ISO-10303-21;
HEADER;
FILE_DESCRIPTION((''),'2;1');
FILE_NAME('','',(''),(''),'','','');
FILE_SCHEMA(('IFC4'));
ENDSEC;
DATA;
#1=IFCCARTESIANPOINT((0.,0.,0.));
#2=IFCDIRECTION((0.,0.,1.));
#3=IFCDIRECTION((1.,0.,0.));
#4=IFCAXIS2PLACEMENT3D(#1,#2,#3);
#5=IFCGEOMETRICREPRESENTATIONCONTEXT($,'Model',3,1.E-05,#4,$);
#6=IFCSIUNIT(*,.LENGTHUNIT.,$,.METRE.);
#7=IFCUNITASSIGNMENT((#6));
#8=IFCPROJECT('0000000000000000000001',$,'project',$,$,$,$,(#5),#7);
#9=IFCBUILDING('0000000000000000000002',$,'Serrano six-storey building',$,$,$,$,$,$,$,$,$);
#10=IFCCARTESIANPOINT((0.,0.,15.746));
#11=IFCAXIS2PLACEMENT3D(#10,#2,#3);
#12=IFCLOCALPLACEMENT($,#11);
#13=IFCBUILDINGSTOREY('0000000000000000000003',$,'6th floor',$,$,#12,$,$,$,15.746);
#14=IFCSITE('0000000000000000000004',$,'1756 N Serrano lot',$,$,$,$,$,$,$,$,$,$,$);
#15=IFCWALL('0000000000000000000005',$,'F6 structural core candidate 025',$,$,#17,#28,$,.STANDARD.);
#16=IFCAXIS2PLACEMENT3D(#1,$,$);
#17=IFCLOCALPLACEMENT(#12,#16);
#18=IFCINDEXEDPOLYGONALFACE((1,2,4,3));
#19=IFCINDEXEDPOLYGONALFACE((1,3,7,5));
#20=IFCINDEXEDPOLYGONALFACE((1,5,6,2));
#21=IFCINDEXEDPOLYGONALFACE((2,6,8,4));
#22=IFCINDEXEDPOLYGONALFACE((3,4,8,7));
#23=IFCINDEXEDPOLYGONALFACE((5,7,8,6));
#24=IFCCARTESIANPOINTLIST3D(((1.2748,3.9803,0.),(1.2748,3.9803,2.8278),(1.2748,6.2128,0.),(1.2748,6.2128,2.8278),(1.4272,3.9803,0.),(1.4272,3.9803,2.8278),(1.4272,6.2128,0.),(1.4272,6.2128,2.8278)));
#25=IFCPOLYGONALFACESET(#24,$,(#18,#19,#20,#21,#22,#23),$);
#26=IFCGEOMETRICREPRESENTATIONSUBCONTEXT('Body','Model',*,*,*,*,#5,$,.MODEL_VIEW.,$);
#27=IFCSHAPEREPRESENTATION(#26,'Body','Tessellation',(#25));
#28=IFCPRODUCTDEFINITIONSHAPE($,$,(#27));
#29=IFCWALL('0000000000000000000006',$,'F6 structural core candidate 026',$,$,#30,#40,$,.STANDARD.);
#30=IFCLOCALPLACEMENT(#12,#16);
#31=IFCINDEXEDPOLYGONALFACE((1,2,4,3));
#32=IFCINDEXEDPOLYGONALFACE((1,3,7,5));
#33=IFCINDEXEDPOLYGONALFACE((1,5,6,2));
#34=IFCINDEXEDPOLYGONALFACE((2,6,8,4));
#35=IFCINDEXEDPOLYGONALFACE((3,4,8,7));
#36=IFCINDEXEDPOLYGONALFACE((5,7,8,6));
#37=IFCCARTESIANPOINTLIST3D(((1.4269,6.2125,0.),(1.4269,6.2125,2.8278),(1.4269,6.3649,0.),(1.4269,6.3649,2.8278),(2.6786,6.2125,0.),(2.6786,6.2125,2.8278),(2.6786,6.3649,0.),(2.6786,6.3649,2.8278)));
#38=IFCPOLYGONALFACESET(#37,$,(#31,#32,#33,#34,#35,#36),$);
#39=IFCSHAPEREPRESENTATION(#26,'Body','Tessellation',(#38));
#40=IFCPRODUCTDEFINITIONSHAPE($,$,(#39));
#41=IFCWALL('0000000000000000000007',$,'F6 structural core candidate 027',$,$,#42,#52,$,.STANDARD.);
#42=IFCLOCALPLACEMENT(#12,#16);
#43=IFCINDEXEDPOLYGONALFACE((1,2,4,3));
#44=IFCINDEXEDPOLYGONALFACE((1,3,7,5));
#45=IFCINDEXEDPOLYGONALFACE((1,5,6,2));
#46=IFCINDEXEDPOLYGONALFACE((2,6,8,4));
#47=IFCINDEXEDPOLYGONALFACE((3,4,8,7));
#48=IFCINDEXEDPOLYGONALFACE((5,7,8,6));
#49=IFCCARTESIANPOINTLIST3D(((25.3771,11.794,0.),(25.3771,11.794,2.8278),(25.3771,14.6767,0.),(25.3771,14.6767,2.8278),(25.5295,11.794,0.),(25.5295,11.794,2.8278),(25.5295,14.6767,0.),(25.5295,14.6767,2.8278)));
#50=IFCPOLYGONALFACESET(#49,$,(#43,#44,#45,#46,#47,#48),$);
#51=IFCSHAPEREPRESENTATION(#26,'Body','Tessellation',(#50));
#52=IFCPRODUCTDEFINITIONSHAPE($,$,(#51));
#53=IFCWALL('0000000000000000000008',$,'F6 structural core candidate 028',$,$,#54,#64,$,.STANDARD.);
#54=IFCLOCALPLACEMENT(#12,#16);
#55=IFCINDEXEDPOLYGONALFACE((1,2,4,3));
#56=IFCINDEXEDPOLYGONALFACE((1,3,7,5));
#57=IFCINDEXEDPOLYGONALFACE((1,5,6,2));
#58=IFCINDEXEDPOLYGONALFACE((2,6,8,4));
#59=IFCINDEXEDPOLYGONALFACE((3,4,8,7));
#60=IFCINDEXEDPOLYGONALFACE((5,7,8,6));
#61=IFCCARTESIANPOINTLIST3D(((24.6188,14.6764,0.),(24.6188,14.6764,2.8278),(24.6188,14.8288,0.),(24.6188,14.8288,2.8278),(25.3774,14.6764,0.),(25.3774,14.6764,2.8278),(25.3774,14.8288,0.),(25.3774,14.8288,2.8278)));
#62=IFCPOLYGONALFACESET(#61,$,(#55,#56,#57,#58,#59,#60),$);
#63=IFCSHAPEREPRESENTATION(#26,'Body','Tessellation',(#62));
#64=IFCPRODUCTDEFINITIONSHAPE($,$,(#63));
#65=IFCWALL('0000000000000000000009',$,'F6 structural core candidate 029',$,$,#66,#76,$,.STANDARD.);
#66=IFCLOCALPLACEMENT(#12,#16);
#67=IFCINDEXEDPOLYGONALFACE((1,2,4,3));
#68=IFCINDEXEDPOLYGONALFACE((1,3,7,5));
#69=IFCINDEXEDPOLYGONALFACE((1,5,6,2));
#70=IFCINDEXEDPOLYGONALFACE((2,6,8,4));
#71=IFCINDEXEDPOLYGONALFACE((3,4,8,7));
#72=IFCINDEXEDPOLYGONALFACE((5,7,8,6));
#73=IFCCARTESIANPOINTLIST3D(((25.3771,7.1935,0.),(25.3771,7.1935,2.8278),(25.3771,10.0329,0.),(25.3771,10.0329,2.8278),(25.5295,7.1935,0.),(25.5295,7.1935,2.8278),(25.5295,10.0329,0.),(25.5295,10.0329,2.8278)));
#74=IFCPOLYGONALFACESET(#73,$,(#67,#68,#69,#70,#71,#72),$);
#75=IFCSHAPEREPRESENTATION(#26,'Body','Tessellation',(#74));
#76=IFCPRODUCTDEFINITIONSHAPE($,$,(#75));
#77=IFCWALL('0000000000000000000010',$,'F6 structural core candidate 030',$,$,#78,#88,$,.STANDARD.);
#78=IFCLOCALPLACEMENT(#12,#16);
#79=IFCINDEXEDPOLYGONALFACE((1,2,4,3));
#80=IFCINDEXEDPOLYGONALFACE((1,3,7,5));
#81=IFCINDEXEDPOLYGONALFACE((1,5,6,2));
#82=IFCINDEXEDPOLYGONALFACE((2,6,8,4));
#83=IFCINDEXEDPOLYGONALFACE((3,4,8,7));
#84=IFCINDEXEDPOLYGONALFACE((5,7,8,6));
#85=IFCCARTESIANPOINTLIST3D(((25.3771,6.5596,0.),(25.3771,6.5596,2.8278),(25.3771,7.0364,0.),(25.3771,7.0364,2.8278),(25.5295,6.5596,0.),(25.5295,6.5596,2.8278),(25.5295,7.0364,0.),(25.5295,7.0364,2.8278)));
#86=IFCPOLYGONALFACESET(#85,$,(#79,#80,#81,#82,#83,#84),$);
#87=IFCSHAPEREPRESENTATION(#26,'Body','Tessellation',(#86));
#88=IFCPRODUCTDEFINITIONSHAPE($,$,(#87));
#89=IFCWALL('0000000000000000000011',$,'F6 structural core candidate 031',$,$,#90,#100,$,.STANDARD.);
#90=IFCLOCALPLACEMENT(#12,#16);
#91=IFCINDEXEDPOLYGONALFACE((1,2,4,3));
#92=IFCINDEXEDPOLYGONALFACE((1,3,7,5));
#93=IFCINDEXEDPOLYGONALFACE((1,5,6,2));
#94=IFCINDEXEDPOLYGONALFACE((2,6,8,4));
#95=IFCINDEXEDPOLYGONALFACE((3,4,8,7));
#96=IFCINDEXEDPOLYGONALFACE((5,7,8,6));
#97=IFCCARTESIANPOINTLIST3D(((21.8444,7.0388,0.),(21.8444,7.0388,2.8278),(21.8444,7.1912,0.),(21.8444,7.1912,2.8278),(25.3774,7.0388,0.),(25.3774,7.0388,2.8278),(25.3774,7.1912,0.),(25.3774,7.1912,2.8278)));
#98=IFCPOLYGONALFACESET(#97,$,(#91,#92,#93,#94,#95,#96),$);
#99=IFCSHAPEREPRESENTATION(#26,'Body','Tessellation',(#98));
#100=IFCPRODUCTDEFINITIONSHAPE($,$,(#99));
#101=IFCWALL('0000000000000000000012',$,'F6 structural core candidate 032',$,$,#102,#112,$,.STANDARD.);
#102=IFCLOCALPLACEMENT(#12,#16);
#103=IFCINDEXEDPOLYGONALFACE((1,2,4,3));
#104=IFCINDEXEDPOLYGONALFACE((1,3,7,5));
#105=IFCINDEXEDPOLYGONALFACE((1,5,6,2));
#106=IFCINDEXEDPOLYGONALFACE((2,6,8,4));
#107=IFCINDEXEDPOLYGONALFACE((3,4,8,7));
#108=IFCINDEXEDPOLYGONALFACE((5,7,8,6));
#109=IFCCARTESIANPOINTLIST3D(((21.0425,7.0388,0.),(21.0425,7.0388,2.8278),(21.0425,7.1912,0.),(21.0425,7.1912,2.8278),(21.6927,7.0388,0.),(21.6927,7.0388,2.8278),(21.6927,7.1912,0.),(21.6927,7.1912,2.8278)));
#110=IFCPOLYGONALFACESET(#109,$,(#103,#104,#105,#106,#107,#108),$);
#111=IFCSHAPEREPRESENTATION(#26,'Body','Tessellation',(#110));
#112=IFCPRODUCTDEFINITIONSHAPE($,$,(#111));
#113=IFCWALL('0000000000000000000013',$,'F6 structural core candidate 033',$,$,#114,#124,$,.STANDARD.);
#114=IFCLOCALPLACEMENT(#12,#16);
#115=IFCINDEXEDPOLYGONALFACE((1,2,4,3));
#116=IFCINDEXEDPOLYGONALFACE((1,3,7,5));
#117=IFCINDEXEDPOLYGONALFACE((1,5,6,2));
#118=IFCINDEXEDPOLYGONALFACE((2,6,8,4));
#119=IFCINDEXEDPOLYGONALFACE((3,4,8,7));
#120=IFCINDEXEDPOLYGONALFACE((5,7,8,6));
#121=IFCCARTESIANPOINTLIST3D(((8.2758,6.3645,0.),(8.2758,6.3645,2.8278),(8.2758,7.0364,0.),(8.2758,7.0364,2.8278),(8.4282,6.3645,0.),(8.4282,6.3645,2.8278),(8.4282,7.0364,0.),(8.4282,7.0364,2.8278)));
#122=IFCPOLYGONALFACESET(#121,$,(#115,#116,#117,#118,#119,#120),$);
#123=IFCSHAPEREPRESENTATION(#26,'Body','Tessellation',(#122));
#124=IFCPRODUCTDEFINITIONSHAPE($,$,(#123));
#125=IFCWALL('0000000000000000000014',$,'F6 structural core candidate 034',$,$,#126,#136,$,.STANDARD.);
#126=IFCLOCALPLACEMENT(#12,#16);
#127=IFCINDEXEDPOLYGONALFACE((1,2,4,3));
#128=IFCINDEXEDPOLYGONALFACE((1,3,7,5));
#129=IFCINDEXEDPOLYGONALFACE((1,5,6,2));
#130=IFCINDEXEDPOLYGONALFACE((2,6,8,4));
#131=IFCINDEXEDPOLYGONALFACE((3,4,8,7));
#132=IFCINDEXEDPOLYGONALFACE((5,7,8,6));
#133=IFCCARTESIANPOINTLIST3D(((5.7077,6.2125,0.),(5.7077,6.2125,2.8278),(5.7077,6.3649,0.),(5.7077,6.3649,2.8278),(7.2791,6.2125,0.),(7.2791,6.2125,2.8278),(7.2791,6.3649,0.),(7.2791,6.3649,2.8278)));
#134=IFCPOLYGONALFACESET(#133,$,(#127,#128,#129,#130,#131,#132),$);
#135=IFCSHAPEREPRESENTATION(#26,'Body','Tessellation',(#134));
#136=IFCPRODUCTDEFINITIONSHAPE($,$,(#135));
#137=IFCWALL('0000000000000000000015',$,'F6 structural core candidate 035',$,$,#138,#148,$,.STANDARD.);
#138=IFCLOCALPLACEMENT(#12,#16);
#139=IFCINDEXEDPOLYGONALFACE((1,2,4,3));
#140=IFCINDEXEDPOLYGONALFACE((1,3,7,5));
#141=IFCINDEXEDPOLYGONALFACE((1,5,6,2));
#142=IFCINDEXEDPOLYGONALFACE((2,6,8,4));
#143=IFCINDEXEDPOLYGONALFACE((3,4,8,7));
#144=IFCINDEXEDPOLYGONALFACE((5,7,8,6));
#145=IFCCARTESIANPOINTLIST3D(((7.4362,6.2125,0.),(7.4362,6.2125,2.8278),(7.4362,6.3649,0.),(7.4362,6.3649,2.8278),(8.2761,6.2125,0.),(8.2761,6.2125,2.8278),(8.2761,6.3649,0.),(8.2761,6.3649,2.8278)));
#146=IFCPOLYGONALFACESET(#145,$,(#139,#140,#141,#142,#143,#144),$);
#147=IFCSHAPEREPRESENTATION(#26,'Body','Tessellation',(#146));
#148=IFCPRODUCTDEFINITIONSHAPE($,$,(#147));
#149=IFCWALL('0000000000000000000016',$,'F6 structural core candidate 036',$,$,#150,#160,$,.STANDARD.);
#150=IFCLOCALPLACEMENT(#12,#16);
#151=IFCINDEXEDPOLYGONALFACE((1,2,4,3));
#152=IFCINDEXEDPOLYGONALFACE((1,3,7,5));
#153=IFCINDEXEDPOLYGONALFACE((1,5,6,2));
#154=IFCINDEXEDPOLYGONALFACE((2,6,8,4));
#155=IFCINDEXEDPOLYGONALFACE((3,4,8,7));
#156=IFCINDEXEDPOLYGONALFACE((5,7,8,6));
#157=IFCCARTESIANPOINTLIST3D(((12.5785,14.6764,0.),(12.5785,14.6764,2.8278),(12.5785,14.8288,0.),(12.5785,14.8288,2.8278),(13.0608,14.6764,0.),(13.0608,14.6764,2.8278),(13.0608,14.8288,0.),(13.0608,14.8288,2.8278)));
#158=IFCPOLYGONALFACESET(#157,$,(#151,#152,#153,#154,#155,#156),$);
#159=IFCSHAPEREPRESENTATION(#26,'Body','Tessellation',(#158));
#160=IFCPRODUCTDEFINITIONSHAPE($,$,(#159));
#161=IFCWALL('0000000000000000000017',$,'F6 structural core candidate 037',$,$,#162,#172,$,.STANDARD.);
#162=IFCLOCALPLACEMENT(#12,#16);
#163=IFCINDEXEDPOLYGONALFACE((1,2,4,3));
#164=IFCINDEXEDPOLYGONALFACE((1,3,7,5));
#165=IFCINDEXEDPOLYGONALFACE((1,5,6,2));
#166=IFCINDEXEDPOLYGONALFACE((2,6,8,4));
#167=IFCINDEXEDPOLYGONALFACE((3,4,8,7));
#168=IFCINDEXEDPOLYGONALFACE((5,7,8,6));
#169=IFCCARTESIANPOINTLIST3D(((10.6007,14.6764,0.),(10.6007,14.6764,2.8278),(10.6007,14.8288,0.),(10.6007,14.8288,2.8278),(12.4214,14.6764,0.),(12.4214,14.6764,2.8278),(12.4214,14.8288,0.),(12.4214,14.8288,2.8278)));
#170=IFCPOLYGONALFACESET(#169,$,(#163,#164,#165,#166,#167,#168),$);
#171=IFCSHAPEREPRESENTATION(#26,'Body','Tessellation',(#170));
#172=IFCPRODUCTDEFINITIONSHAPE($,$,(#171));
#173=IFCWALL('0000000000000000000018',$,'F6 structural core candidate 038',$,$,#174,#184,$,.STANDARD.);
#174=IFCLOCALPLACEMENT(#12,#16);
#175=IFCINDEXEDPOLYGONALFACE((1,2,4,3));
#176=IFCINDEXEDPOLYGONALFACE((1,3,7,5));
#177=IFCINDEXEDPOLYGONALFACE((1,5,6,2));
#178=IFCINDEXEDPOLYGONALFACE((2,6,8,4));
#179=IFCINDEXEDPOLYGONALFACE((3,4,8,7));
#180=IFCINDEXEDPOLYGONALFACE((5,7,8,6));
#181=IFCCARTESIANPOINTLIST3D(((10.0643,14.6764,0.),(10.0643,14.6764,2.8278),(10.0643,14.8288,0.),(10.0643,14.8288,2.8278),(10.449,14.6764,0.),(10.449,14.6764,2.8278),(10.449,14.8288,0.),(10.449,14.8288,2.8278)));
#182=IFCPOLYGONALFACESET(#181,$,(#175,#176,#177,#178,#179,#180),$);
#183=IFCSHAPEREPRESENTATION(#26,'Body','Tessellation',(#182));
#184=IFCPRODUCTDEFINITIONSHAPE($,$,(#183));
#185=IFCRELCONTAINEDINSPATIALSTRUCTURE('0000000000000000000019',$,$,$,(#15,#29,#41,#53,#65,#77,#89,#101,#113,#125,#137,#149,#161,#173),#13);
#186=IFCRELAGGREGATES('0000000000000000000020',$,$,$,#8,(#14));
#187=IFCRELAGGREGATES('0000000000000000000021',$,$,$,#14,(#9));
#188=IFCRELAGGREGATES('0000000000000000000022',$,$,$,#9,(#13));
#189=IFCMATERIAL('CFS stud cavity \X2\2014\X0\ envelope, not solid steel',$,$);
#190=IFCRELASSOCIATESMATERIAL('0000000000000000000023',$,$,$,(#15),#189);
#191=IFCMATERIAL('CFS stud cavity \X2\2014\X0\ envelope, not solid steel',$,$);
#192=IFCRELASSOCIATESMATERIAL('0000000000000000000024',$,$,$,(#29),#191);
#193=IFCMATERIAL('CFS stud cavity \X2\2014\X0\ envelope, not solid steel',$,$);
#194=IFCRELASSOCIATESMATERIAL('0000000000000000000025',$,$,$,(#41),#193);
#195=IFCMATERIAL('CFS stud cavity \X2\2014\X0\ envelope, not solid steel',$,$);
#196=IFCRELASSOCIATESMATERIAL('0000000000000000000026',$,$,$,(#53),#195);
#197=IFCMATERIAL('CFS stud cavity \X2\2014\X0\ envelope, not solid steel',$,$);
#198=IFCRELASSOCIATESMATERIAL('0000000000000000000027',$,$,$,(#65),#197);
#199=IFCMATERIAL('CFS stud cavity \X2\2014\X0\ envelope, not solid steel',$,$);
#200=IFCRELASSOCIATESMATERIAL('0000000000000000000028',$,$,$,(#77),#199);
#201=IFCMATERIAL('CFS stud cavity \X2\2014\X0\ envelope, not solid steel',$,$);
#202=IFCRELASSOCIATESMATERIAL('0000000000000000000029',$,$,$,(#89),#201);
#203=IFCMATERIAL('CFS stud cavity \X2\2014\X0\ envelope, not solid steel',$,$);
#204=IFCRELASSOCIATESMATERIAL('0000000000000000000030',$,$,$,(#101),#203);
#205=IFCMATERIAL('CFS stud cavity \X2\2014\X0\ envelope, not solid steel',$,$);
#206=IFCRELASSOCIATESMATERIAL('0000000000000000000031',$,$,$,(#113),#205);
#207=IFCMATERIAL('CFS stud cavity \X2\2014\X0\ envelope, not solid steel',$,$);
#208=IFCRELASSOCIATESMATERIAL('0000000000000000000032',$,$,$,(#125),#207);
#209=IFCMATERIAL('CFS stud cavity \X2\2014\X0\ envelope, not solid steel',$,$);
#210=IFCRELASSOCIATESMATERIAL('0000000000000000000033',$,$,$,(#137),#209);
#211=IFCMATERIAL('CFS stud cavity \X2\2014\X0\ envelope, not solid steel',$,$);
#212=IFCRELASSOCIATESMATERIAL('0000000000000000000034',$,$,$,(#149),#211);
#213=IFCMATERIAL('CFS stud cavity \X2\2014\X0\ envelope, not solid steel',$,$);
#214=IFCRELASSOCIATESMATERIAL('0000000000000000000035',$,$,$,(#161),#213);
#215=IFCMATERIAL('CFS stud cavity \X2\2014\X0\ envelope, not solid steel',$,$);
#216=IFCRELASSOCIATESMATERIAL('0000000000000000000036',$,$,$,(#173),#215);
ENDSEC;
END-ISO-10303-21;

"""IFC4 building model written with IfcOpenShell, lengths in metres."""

from ifc_helpers import new_model, si_unit, frame, origin_with_axes, place, context, subcontext, project, spatial, polyline, outline, extrude, material, element, save


model = new_model("IFC4")

# Units and contexts
model_context = context("Model", 3, precision=1e-05, world=origin_with_axes())
body_context = subcontext(model_context, "Body", "Model", "MODEL_VIEW")
ifc_project = project(units=[si_unit("LENGTHUNIT", "METRE")], contexts=[model_context])

# Site, building, storey
site = spatial("IfcSite", under=ifc_project, Name="1756 N Serrano lot")
building = spatial("IfcBuilding", under=site, Name="Serrano six-storey building")
storey_placement = place(None, frame((0.0, 0.0, 15.746), z_axis=(0.0, 0.0, 1.0), x_axis=(1.0, 0.0, 0.0)))
storey = spatial("IfcBuildingStorey", under=building, at=storey_placement, Name="6th floor", Elevation=15.746)

# Walls
ifc_material_1 = material(Name="CFS stud cavity — envelope, not solid steel")
wall_1_placement = place(storey_placement, frame((0.0, 0.0, -15.746), z_axis=(0.0, 0.0, 1.0), x_axis=(1.0, 0.0, 0.0)))
element("IfcWall", 1, at=wall_1_placement, inside=storey, material=ifc_material_1, Name="F6 structural core candidate 025", PredefinedType="STANDARD", context=body_context, shape_type="SweptSolid", body=[
    extrude(outline(polyline([(1.4272, 3.9803), (1.2748, 3.9803), (1.2748, 6.2128), (1.4272, 6.2128), (1.4272, 3.9803)])), frame((0.0, 0.0, 15.746)), (0.0, 0.0, 1.0), 2.8278),
])
ifc_material_2 = material(Name="CFS stud cavity — envelope, not solid steel")
wall_2_placement = place(storey_placement, frame((0.0, 0.0, -15.746), z_axis=(0.0, 0.0, 1.0), x_axis=(1.0, 0.0, 0.0)))
element("IfcWall", 2, at=wall_2_placement, inside=storey, material=ifc_material_2, Name="F6 structural core candidate 026", PredefinedType="STANDARD", context=body_context, shape_type="SweptSolid", body=[
    extrude(outline(polyline([(2.6786, 6.3649), (2.6786, 6.2125), (1.4269, 6.2125), (1.4269, 6.3649), (2.6786, 6.3649)])), frame((0.0, 0.0, 15.746)), (0.0, 0.0, 1.0), 2.8278),
])
ifc_material_3 = material(Name="CFS stud cavity — envelope, not solid steel")
wall_3_placement = place(storey_placement, frame((0.0, 0.0, -15.746), z_axis=(0.0, 0.0, 1.0), x_axis=(1.0, 0.0, 0.0)))
element("IfcWall", 3, at=wall_3_placement, inside=storey, material=ifc_material_3, Name="F6 structural core candidate 027", PredefinedType="STANDARD", context=body_context, shape_type="SweptSolid", body=[
    extrude(outline(polyline([(25.5295, 11.794), (25.3771, 11.794), (25.3771, 14.6767), (25.5295, 14.6767), (25.5295, 11.794)])), frame((0.0, 0.0, 15.746)), (0.0, 0.0, 1.0), 2.8278),
])
ifc_material_4 = material(Name="CFS stud cavity — envelope, not solid steel")
wall_4_placement = place(storey_placement, frame((0.0, 0.0, -15.746), z_axis=(0.0, 0.0, 1.0), x_axis=(1.0, 0.0, 0.0)))
element("IfcWall", 4, at=wall_4_placement, inside=storey, material=ifc_material_4, Name="F6 structural core candidate 028", PredefinedType="STANDARD", context=body_context, shape_type="SweptSolid", body=[
    extrude(outline(polyline([(25.3774, 14.8288), (25.3774, 14.6764), (24.6188, 14.6764), (24.6188, 14.8288), (25.3774, 14.8288)])), frame((0.0, 0.0, 15.746)), (0.0, 0.0, 1.0), 2.8278),
])
ifc_material_5 = material(Name="CFS stud cavity — envelope, not solid steel")
wall_5_placement = place(storey_placement, frame((0.0, 0.0, -15.746), z_axis=(0.0, 0.0, 1.0), x_axis=(1.0, 0.0, 0.0)))
element("IfcWall", 5, at=wall_5_placement, inside=storey, material=ifc_material_5, Name="F6 structural core candidate 029", PredefinedType="STANDARD", context=body_context, shape_type="SweptSolid", body=[
    extrude(outline(polyline([(25.5295, 7.1935), (25.3771, 7.1935), (25.3771, 10.0329), (25.5295, 10.0329), (25.5295, 7.1935)])), frame((0.0, 0.0, 15.746)), (0.0, 0.0, 1.0), 2.8278),
])
ifc_material_6 = material(Name="CFS stud cavity — envelope, not solid steel")
wall_6_placement = place(storey_placement, frame((0.0, 0.0, -15.746), z_axis=(0.0, 0.0, 1.0), x_axis=(1.0, 0.0, 0.0)))
element("IfcWall", 6, at=wall_6_placement, inside=storey, material=ifc_material_6, Name="F6 structural core candidate 030", PredefinedType="STANDARD", context=body_context, shape_type="SweptSolid", body=[
    extrude(outline(polyline([(25.5295, 6.5596), (25.3771, 6.5596), (25.3771, 7.0364), (25.5295, 7.0364), (25.5295, 6.5596)])), frame((0.0, 0.0, 15.746)), (0.0, 0.0, 1.0), 2.8278),
])
ifc_material_7 = material(Name="CFS stud cavity — envelope, not solid steel")
wall_7_placement = place(storey_placement, frame((0.0, 0.0, -15.746), z_axis=(0.0, 0.0, 1.0), x_axis=(1.0, 0.0, 0.0)))
element("IfcWall", 7, at=wall_7_placement, inside=storey, material=ifc_material_7, Name="F6 structural core candidate 031", PredefinedType="STANDARD", context=body_context, shape_type="SweptSolid", body=[
    extrude(outline(polyline([(25.3774, 7.1912), (25.3774, 7.0388), (21.8444, 7.0388), (21.8444, 7.1912), (25.3774, 7.1912)])), frame((0.0, 0.0, 15.746)), (0.0, 0.0, 1.0), 2.8278),
])
ifc_material_8 = material(Name="CFS stud cavity — envelope, not solid steel")
wall_8_placement = place(storey_placement, frame((0.0, 0.0, -15.746), z_axis=(0.0, 0.0, 1.0), x_axis=(1.0, 0.0, 0.0)))
element("IfcWall", 8, at=wall_8_placement, inside=storey, material=ifc_material_8, Name="F6 structural core candidate 032", PredefinedType="STANDARD", context=body_context, shape_type="SweptSolid", body=[
    extrude(outline(polyline([(21.6927, 7.1912), (21.6927, 7.0388), (21.0425, 7.0388), (21.0425, 7.1912), (21.6927, 7.1912)])), frame((0.0, 0.0, 15.746)), (0.0, 0.0, 1.0), 2.8278),
])
ifc_material_9 = material(Name="CFS stud cavity — envelope, not solid steel")
wall_9_placement = place(storey_placement, frame((0.0, 0.0, -15.746), z_axis=(0.0, 0.0, 1.0), x_axis=(1.0, 0.0, 0.0)))
element("IfcWall", 9, at=wall_9_placement, inside=storey, material=ifc_material_9, Name="F6 structural core candidate 033", PredefinedType="STANDARD", context=body_context, shape_type="SweptSolid", body=[
    extrude(outline(polyline([(8.4282, 6.3645), (8.2758, 6.3645), (8.2758, 7.0364), (8.4282, 7.0364), (8.4282, 6.3645)])), frame((0.0, 0.0, 15.746)), (0.0, 0.0, 1.0), 2.8278),
])
ifc_material_10 = material(Name="CFS stud cavity — envelope, not solid steel")
wall_10_placement = place(storey_placement, frame((0.0, 0.0, -15.746), z_axis=(0.0, 0.0, 1.0), x_axis=(1.0, 0.0, 0.0)))
element("IfcWall", 10, at=wall_10_placement, inside=storey, material=ifc_material_10, Name="F6 structural core candidate 034", PredefinedType="STANDARD", context=body_context, shape_type="SweptSolid", body=[
    extrude(outline(polyline([(7.2791, 6.3649), (7.2791, 6.2125), (5.7077, 6.2125), (5.7077, 6.3649), (7.2791, 6.3649)])), frame((0.0, 0.0, 15.746)), (0.0, 0.0, 1.0), 2.8278),
])
ifc_material_11 = material(Name="CFS stud cavity — envelope, not solid steel")
wall_11_placement = place(storey_placement, frame((0.0, 0.0, -15.746), z_axis=(0.0, 0.0, 1.0), x_axis=(1.0, 0.0, 0.0)))
element("IfcWall", 11, at=wall_11_placement, inside=storey, material=ifc_material_11, Name="F6 structural core candidate 035", PredefinedType="STANDARD", context=body_context, shape_type="SweptSolid", body=[
    extrude(outline(polyline([(8.2761, 6.3649), (8.2761, 6.2125), (7.4362, 6.2125), (7.4362, 6.3649), (8.2761, 6.3649)])), frame((0.0, 0.0, 15.746)), (0.0, 0.0, 1.0), 2.8278),
])
ifc_material_12 = material(Name="CFS stud cavity — envelope, not solid steel")
wall_12_placement = place(storey_placement, frame((0.0, 0.0, -15.746), z_axis=(0.0, 0.0, 1.0), x_axis=(1.0, 0.0, 0.0)))
element("IfcWall", 12, at=wall_12_placement, inside=storey, material=ifc_material_12, Name="F6 structural core candidate 036", PredefinedType="STANDARD", context=body_context, shape_type="SweptSolid", body=[
    extrude(outline(polyline([(13.0608, 14.8288), (13.0608, 14.6764), (12.5785, 14.6764), (12.5785, 14.8288), (13.0608, 14.8288)])), frame((0.0, 0.0, 15.746)), (0.0, 0.0, 1.0), 2.8278),
])
ifc_material_13 = material(Name="CFS stud cavity — envelope, not solid steel")
wall_13_placement = place(storey_placement, frame((0.0, 0.0, -15.746), z_axis=(0.0, 0.0, 1.0), x_axis=(1.0, 0.0, 0.0)))
element("IfcWall", 13, at=wall_13_placement, inside=storey, material=ifc_material_13, Name="F6 structural core candidate 037", PredefinedType="STANDARD", context=body_context, shape_type="SweptSolid", body=[
    extrude(outline(polyline([(12.4214, 14.8288), (12.4214, 14.6764), (10.6007, 14.6764), (10.6007, 14.8288), (12.4214, 14.8288)])), frame((0.0, 0.0, 15.746)), (0.0, 0.0, 1.0), 2.8278),
])
ifc_material_14 = material(Name="CFS stud cavity — envelope, not solid steel")
wall_14_placement = place(storey_placement, frame((0.0, 0.0, -15.746), z_axis=(0.0, 0.0, 1.0), x_axis=(1.0, 0.0, 0.0)))
element("IfcWall", 14, at=wall_14_placement, inside=storey, material=ifc_material_14, Name="F6 structural core candidate 038", PredefinedType="STANDARD", context=body_context, shape_type="SweptSolid", body=[
    extrude(outline(polyline([(10.449, 14.8288), (10.449, 14.6764), (10.0643, 14.6764), (10.0643, 14.8288), (10.449, 14.8288)])), frame((0.0, 0.0, 15.746)), (0.0, 0.0, 1.0), 2.8278),
])

save(model, "model.ifc")
